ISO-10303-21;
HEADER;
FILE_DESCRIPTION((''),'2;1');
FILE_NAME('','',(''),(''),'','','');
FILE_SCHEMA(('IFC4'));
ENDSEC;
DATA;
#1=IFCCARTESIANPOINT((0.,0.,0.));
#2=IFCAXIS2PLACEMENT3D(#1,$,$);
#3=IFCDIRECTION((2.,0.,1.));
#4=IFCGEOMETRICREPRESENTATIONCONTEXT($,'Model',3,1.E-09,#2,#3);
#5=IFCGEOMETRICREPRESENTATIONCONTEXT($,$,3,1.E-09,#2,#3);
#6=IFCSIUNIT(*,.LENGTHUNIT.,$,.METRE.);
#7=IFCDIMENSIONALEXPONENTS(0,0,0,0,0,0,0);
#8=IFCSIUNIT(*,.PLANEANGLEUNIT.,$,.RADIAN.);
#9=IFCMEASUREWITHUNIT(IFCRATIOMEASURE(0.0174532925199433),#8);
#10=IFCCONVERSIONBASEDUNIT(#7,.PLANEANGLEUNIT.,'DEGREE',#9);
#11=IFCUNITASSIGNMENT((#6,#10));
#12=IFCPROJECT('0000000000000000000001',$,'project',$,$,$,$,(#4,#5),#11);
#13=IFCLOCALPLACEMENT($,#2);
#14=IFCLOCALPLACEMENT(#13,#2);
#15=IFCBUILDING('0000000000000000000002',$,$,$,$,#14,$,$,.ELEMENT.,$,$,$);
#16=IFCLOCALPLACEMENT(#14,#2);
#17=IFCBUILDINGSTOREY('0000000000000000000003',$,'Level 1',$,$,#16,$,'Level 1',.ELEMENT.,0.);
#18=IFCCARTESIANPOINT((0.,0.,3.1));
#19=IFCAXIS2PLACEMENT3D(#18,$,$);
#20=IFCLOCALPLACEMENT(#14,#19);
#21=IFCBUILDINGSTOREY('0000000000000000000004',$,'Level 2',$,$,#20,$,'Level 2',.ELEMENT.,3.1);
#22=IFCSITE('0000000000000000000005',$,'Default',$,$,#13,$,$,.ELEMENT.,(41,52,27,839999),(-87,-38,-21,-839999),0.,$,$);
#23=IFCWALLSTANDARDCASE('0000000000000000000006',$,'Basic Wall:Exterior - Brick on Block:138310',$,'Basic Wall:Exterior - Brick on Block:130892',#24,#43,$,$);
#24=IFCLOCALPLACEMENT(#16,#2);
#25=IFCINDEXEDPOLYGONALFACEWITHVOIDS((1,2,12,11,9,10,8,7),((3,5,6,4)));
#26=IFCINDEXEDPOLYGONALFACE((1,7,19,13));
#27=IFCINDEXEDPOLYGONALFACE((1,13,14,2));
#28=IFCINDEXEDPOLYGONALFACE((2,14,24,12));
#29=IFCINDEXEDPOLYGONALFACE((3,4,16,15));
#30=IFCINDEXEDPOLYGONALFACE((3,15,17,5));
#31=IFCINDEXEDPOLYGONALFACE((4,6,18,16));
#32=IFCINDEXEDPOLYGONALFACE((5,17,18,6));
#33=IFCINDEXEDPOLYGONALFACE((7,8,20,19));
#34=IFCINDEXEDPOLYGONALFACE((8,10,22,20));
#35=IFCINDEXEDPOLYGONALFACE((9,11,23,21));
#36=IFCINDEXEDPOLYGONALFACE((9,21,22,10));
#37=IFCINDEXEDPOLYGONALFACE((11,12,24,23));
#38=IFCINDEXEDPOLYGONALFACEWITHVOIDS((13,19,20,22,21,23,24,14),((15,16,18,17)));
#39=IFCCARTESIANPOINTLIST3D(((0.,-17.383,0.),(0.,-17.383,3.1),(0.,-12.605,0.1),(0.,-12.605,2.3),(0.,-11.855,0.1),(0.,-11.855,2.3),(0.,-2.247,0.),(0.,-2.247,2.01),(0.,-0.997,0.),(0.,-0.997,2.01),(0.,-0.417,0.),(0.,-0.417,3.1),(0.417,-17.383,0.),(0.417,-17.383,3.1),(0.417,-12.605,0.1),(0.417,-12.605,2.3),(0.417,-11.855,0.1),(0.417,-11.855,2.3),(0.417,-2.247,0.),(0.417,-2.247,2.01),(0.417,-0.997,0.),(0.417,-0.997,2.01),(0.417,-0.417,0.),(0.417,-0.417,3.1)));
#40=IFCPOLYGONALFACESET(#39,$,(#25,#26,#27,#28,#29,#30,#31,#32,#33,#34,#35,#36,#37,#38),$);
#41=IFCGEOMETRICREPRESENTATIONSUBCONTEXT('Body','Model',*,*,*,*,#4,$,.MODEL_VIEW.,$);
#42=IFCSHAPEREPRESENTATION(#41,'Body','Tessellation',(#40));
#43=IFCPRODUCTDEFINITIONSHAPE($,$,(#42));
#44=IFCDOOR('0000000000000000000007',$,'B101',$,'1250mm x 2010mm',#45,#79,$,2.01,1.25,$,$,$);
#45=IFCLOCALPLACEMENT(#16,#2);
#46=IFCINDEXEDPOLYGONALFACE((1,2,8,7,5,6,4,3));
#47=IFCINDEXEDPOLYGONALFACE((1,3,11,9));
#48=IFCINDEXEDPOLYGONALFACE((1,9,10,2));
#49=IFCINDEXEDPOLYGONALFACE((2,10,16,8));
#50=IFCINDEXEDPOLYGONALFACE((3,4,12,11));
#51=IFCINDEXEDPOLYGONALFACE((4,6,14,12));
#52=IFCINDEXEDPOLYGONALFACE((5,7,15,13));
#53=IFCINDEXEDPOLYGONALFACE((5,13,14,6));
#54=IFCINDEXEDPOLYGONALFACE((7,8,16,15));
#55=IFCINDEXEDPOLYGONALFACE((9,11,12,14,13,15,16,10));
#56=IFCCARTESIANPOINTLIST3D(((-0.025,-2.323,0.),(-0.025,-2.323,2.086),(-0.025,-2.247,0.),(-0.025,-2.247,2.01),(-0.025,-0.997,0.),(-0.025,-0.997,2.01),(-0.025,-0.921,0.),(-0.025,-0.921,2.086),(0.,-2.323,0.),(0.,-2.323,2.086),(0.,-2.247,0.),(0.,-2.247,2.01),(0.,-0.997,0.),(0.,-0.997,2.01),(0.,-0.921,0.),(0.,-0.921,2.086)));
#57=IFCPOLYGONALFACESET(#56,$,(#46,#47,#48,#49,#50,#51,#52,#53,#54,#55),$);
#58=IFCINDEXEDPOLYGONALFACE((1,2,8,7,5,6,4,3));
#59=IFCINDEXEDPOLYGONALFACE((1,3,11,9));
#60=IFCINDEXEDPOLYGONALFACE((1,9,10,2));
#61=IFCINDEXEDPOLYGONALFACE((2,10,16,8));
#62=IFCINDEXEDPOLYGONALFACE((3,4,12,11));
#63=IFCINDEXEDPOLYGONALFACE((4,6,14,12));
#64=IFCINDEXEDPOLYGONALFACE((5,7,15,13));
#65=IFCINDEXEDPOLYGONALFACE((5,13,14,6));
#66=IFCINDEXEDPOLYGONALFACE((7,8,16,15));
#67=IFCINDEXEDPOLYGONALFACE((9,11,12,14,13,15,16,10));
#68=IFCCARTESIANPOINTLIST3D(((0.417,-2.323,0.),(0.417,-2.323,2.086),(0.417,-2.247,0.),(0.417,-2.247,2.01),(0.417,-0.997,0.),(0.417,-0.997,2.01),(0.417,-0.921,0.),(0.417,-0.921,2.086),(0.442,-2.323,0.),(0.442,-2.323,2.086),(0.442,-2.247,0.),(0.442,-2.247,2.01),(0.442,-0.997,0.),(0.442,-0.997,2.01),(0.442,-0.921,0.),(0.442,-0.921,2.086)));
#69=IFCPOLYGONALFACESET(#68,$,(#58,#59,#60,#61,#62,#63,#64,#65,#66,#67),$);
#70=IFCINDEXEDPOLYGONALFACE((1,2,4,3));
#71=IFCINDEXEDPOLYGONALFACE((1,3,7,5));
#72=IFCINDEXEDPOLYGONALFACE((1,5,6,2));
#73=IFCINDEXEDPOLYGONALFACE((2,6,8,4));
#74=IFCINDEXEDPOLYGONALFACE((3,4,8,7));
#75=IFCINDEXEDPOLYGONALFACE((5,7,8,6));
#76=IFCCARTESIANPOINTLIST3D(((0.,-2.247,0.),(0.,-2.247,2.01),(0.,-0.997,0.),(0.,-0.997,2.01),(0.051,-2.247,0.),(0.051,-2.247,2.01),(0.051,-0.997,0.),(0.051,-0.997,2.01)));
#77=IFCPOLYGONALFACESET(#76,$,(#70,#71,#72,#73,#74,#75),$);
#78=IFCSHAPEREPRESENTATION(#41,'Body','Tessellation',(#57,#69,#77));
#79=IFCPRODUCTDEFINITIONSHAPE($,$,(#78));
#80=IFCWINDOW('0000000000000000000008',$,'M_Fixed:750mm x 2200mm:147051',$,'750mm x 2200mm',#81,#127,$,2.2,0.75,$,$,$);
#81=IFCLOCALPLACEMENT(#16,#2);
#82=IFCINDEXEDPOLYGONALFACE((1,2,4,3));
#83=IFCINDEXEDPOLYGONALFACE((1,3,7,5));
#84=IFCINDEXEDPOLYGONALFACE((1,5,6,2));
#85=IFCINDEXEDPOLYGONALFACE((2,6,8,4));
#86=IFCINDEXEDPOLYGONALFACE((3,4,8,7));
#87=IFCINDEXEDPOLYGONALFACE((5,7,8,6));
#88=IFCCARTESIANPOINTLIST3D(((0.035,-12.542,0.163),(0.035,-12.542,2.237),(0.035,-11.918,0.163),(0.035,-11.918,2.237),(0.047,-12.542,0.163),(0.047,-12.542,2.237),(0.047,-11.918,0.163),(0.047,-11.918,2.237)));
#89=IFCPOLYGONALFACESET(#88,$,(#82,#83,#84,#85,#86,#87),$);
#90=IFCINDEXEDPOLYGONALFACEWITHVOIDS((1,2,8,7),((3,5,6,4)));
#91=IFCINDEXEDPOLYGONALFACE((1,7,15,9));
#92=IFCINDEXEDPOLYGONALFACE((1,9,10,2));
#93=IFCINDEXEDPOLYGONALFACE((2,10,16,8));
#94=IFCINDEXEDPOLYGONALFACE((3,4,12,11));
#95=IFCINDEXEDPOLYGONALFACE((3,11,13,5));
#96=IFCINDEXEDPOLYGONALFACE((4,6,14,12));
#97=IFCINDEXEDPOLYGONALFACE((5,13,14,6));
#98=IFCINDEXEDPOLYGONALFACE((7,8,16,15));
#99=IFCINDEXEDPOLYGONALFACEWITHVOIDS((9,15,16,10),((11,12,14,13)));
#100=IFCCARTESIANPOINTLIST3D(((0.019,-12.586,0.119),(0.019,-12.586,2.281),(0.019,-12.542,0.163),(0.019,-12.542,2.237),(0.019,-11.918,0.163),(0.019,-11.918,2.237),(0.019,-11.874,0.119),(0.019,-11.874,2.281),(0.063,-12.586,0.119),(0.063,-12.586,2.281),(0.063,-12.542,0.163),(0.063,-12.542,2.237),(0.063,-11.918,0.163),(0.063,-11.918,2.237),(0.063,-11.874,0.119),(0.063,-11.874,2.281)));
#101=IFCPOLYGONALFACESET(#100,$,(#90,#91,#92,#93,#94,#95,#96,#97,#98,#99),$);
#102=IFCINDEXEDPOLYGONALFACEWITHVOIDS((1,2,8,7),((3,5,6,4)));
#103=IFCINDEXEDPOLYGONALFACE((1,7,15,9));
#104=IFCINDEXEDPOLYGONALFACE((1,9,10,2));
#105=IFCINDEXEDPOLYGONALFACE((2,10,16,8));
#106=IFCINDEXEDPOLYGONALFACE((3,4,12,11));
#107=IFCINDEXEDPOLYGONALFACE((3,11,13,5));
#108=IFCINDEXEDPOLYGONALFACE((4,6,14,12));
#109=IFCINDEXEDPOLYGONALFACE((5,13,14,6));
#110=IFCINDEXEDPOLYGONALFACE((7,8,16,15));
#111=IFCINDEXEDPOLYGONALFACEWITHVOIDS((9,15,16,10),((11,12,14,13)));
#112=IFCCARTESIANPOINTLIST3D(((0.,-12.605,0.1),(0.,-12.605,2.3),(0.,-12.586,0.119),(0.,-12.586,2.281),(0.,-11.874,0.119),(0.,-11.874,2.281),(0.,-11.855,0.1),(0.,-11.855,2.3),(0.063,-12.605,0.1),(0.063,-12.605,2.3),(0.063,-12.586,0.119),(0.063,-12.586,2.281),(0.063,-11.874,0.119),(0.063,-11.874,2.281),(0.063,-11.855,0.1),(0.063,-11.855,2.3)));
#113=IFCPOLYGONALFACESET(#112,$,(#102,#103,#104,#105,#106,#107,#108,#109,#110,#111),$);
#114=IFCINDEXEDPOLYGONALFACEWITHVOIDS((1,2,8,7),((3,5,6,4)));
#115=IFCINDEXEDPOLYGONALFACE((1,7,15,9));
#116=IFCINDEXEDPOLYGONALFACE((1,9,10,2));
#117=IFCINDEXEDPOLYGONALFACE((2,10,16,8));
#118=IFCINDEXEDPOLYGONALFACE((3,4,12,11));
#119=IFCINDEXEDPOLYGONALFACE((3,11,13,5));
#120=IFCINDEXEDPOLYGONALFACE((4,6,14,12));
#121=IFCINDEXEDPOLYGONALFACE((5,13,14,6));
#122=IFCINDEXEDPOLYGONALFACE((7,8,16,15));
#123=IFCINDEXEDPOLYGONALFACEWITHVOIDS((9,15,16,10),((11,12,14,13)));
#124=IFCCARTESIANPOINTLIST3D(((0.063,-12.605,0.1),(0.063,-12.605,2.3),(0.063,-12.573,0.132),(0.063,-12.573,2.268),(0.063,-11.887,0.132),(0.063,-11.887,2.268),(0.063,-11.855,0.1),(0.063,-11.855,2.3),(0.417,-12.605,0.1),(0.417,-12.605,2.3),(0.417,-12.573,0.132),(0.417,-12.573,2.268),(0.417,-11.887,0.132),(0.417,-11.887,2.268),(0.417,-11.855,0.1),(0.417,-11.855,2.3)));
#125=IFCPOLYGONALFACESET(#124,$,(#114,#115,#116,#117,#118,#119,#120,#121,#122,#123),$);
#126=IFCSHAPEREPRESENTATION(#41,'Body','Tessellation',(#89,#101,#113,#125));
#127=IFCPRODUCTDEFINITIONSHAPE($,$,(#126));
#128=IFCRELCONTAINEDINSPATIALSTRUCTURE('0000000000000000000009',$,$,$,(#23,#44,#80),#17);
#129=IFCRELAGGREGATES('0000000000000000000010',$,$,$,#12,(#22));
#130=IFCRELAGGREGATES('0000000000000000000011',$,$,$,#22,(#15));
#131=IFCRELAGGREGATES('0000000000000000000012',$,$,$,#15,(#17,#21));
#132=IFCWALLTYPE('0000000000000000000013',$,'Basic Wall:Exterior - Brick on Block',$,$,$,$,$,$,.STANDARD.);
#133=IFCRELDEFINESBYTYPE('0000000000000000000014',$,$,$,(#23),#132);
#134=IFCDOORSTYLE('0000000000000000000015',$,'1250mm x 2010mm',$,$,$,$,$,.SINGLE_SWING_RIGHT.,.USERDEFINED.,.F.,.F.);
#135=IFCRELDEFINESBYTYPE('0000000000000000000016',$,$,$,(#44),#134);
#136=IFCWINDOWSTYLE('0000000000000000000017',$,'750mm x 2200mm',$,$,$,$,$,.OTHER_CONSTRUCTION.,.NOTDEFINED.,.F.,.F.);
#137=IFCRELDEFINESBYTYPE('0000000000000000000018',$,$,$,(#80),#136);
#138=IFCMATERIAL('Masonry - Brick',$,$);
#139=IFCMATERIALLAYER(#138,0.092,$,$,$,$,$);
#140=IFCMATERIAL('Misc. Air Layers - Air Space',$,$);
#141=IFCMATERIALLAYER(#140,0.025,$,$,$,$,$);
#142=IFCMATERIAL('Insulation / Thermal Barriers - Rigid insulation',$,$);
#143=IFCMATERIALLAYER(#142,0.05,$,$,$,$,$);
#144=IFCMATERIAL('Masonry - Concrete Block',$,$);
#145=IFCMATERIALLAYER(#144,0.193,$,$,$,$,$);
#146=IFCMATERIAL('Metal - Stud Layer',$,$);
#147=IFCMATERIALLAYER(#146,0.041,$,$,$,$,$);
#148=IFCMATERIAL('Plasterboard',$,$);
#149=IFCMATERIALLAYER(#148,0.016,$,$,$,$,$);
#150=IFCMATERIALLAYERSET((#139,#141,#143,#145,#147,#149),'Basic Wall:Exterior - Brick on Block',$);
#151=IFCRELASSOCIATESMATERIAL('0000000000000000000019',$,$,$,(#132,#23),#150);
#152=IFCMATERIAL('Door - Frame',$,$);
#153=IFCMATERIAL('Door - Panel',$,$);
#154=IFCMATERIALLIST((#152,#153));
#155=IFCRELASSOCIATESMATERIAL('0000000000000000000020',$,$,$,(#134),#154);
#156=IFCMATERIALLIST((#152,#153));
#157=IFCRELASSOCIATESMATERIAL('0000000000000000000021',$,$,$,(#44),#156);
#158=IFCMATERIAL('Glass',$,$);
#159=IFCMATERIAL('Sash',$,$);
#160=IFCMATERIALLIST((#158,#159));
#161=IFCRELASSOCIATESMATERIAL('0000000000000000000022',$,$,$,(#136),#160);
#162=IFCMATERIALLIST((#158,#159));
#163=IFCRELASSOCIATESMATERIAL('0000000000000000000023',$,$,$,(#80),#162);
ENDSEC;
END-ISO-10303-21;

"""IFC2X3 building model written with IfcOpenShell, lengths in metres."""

from ifc_helpers import new_model, entity, si_unit, converted_unit, direction, frame, frame_2d, origin, origin_2d_with_axis, place, context, subcontext, project, spatial, polyline, rectangle, outline, extrude, source, transform, mapped, material, material_list, layer, layer_set, layer_usage, type_object, type_shapes, element, fill, save


model = new_model("IFC2X3")

# Units and contexts
model_context = context("Model", 3, precision=1e-09, world=origin(), true_north=direction((2.0, 0.0, 1.0)))
context_of_model = context(None, 3, precision=1e-09, world=origin(), true_north=direction((2.0, 0.0, 1.0)))
body_context = subcontext(model_context, "Body", "Model", "MODEL_VIEW")
ifc_project = project(units=[si_unit("LENGTHUNIT", "METRE"), converted_unit("PLANEANGLEUNIT", "DEGREE", entity("IfcRatioMeasure", 0.0174532925199433), si_unit("PLANEANGLEUNIT", "RADIAN"), dimensions=[0, 0, 0, 0, 0, 0, 0])], contexts=[model_context, context_of_model])

# Site, building, storey
site_placement = place(None, origin())
site = spatial("IfcSite", under=ifc_project, at=site_placement, Name="Default", CompositionType="ELEMENT", RefLatitude=(41, 52, 27, 839999), RefLongitude=(-87, -38, -21, -839999), RefElevation=0.0)
building_placement = place(site_placement, origin())
building = spatial("IfcBuilding", under=site, at=building_placement, CompositionType="ELEMENT")
storey_1_placement = place(building_placement, origin())
storey_1 = spatial("IfcBuildingStorey", under=building, at=storey_1_placement, Name="Level 1", LongName="Level 1", CompositionType="ELEMENT", Elevation=0.0)

# Shared definitions
ifc_material_1 = material(Name="Masonry - Brick")
ifc_layer_1 = layer(ifc_material_1, 0.092)
ifc_material_2 = material(Name="Misc. Air Layers - Air Space")
ifc_layer_2 = layer(ifc_material_2, 0.025)
ifc_material_3 = material(Name="Insulation / Thermal Barriers - Rigid insulation")
ifc_layer_3 = layer(ifc_material_3, 0.05)
ifc_material_4 = material(Name="Masonry - Concrete Block")
ifc_layer_4 = layer(ifc_material_4, 0.193)
ifc_material_5 = material(Name="Metal - Stud Layer")
ifc_layer_5 = layer(ifc_material_5, 0.041)
ifc_material_6 = material(Name="Plasterboard")
ifc_layer_6 = layer(ifc_material_6, 0.016)
ifc_layer_set_1 = layer_set([ifc_layer_1, ifc_layer_2, ifc_layer_3, ifc_layer_4, ifc_layer_5, ifc_layer_6], Name="Basic Wall:Exterior - Brick on Block")
wall_type_1 = type_object("IfcWallType", Name="Basic Wall:Exterior - Brick on Block", PredefinedType="STANDARD", material=ifc_layer_set_1)
ifc_material_7 = material(Name="Glass")
ifc_material_8 = material(Name="Sash")
ifc_material_9 = material(Name="Door - Frame")
ifc_material_10 = material(Name="Door - Panel")

# Wall, openings, door, window
ifc_layer_usage_1 = layer_usage(ifc_layer_set_1, "AXIS2", "NEGATIVE", 0.2085)
wall_1_placement = place(storey_1_placement, frame((0.2085, -17.383, 0.0), z_axis=(0.0, 0.0, 1.0), x_axis=(0.0, 1.0, 0.0)))
wall_1 = element("IfcWallStandardCase", 1, at=wall_1_placement, inside=storey_1, type_object=wall_type_1, material=ifc_layer_usage_1, Name="Basic Wall:Exterior - Brick on Block:138310", ObjectType="Basic Wall:Exterior - Brick on Block:130892", context=body_context, shape_type="SweptSolid", body=[
    extrude(rectangle(XDim=16.966, YDim=0.417, at=frame_2d((8.483, 0.0), x_axis=(-1.0, 0.0))), origin(), (0.0, 0.0, 1.0), 3.1),
])
opening_1_placement = place(wall_1_placement, frame((15.136, -0.2085, 0.0)))
opening_1 = element("IfcOpeningElement", 2, at=opening_1_placement, cuts=wall_1, ObjectType="Opening", context=body_context, shape_type="SweptSolid", body=[
    extrude(rectangle(XDim=1.25, YDim=2.01, at=frame_2d((1.005, 0.625), x_axis=(0.0, 1.0))), frame((0.0, 0.0, 0.0), z_axis=(0.0, 1.0, 0.0), x_axis=(0.0, 0.0, 1.0)), (0.0, 0.0, 1.0), 0.417),
])
opening_2_placement = place(wall_1_placement, frame((4.778, -0.2085, 0.1)))
opening_2 = element("IfcOpeningElement", 3, at=opening_2_placement, cuts=wall_1, ObjectType="Opening", context=body_context, shape_type="SweptSolid", body=[
    extrude(rectangle(XDim=2.2, YDim=0.75, at=frame_2d((1.1, 0.375), x_axis=(1.0, 0.0))), frame((0.0, 0.0, 0.0), z_axis=(0.0, 1.0, 0.0), x_axis=(0.0, 0.0, 1.0)), (0.0, 0.0, 1.0), 0.417),
])
ifc_material_list_1 = material_list([ifc_material_9, ifc_material_10])
ifc_material_list_2 = material_list([ifc_material_9, ifc_material_10])
door_style_1 = type_object("IfcDoorStyle", Name="1250mm x 2010mm", ConstructionType="USERDEFINED", OperationType="SINGLE_SWING_RIGHT", ParameterTakesPrecedence=False, Sizeable=False, material=ifc_material_list_2)
shared_shape_1 = source(origin(), body_context, "Body", "SweptSolid", [
    extrude(outline(polyline([(-0.701, -1.062), (0.701, -1.062), (0.701, 1.024), (0.625, 1.024), (0.625, -0.986), (-0.625, -0.986), (-0.625, 1.024), (-0.701, 1.024), (-0.701, -1.062)])), frame((0.625, 0.417, 1.024), z_axis=(0.0, 1.0, 0.0), x_axis=(1.0, 0.0, 0.0)), (0.0, 0.0, 1.0), 0.025),
    extrude(outline(polyline([(-1.062, -0.701), (1.024, -0.701), (1.024, -0.625), (-0.986, -0.625), (-0.986, 0.625), (1.024, 0.625), (1.024, 0.701), (-1.062, 0.701), (-1.062, -0.701)])), frame((0.625, -0.025, 1.024), z_axis=(0.0, 1.0, 0.0), x_axis=(0.0, 0.0, -1.0)), (0.0, 0.0, 1.0), 0.025),
    extrude(rectangle(XDim=0.051, YDim=1.25, at=frame_2d((0.0, 0.0), x_axis=(1.0, 0.0))), frame((0.625, 0.3915, 0.0), z_axis=(0.0, 0.0, 1.0), x_axis=(0.0, 1.0, 0.0)), (0.0, 0.0, 1.0), 2.01),
])
type_shapes(door_style_1, [shared_shape_1])
door_1_placement = place(opening_1_placement, origin())
door_1 = element("IfcDoor", 4, at=door_1_placement, inside=storey_1, type_object=door_style_1, material=ifc_material_list_1, Name="B101", ObjectType="1250mm x 2010mm", OverallHeight=2.01, OverallWidth=1.25, context=body_context, shape_type="MappedRepresentation", body=[
    mapped(shared_shape_1, transform((0.0, 0.0, 0.0), scale=1.0)),
])
fill(opening_1, door_1)
ifc_material_list_3 = material_list([ifc_material_7, ifc_material_8])
ifc_material_list_4 = material_list([ifc_material_7, ifc_material_8])
window_style_1 = type_object("IfcWindowStyle", Name="750mm x 2200mm", ConstructionType="OTHER_CONSTRUCTION", OperationType="NOTDEFINED", ParameterTakesPrecedence=False, Sizeable=False, material=ifc_material_list_4)
shared_shape_2 = source(origin(), body_context, "Body", "SweptSolid", [
    extrude(rectangle(XDim=0.012, YDim=0.624, at=origin_2d_with_axis()), frame((0.375, 0.376, 0.063), z_axis=(0.0, 0.0, 1.0), x_axis=(0.0, -1.0, 0.0)), (0.0, 0.0, 1.0), 2.074),
    extrude(outline(polyline([(-0.356, -1.081), (0.356, -1.081), (0.356, 1.081), (-0.356, 1.081), (-0.356, -1.081)]), holes=[polyline([(-0.312, -1.037), (-0.312, 1.037), (0.312, 1.037), (0.312, -1.037), (-0.312, -1.037)])]), frame((0.375, 0.354, 1.1), z_axis=(0.0, 1.0, 0.0), x_axis=(1.0, 0.0, 0.0)), (0.0, 0.0, 1.0), 0.044),
    extrude(outline(polyline([(-0.375, -1.1), (0.375, -1.1), (0.375, 1.1), (-0.375, 1.1), (-0.375, -1.1)]), holes=[polyline([(-0.356, -1.081), (-0.356, 1.081), (0.356, 1.081), (0.356, -1.081), (-0.356, -1.081)])]), frame((0.375, 0.354, 1.1), z_axis=(0.0, 1.0, 0.0), x_axis=(1.0, 0.0, 0.0)), (0.0, 0.0, 1.0), 0.063),
    extrude(outline(polyline([(-0.375, -1.1), (0.375, -1.1), (0.375, 1.1), (-0.375, 1.1), (-0.375, -1.1)]), holes=[polyline([(-0.343, -1.068), (-0.343, 1.068), (0.343, 1.068), (0.343, -1.068), (-0.343, -1.068)])]), frame((0.375, 0.0, 1.1), z_axis=(0.0, 1.0, 0.0), x_axis=(1.0, 0.0, 0.0)), (0.0, 0.0, 1.0), 0.354),
])
type_shapes(window_style_1, [shared_shape_2])
window_1_placement = place(opening_2_placement, origin())
window_1 = element("IfcWindow", 5, at=window_1_placement, inside=storey_1, type_object=window_style_1, material=ifc_material_list_3, Name="M_Fixed:750mm x 2200mm:147051", ObjectType="750mm x 2200mm", OverallHeight=2.2, OverallWidth=0.75, context=body_context, shape_type="MappedRepresentation", body=[
    mapped(shared_shape_2, transform((0.0, 0.0, 0.0), scale=1.0)),
])
fill(opening_2, window_1)

# Shared definitions
storey_2_placement = place(building_placement, frame((0.0, 0.0, 3.1)))
storey_2 = spatial("IfcBuildingStorey", under=building, at=storey_2_placement, Name="Level 2", LongName="Level 2", CompositionType="ELEMENT", Elevation=3.1)

save(model, "model.ifc")
